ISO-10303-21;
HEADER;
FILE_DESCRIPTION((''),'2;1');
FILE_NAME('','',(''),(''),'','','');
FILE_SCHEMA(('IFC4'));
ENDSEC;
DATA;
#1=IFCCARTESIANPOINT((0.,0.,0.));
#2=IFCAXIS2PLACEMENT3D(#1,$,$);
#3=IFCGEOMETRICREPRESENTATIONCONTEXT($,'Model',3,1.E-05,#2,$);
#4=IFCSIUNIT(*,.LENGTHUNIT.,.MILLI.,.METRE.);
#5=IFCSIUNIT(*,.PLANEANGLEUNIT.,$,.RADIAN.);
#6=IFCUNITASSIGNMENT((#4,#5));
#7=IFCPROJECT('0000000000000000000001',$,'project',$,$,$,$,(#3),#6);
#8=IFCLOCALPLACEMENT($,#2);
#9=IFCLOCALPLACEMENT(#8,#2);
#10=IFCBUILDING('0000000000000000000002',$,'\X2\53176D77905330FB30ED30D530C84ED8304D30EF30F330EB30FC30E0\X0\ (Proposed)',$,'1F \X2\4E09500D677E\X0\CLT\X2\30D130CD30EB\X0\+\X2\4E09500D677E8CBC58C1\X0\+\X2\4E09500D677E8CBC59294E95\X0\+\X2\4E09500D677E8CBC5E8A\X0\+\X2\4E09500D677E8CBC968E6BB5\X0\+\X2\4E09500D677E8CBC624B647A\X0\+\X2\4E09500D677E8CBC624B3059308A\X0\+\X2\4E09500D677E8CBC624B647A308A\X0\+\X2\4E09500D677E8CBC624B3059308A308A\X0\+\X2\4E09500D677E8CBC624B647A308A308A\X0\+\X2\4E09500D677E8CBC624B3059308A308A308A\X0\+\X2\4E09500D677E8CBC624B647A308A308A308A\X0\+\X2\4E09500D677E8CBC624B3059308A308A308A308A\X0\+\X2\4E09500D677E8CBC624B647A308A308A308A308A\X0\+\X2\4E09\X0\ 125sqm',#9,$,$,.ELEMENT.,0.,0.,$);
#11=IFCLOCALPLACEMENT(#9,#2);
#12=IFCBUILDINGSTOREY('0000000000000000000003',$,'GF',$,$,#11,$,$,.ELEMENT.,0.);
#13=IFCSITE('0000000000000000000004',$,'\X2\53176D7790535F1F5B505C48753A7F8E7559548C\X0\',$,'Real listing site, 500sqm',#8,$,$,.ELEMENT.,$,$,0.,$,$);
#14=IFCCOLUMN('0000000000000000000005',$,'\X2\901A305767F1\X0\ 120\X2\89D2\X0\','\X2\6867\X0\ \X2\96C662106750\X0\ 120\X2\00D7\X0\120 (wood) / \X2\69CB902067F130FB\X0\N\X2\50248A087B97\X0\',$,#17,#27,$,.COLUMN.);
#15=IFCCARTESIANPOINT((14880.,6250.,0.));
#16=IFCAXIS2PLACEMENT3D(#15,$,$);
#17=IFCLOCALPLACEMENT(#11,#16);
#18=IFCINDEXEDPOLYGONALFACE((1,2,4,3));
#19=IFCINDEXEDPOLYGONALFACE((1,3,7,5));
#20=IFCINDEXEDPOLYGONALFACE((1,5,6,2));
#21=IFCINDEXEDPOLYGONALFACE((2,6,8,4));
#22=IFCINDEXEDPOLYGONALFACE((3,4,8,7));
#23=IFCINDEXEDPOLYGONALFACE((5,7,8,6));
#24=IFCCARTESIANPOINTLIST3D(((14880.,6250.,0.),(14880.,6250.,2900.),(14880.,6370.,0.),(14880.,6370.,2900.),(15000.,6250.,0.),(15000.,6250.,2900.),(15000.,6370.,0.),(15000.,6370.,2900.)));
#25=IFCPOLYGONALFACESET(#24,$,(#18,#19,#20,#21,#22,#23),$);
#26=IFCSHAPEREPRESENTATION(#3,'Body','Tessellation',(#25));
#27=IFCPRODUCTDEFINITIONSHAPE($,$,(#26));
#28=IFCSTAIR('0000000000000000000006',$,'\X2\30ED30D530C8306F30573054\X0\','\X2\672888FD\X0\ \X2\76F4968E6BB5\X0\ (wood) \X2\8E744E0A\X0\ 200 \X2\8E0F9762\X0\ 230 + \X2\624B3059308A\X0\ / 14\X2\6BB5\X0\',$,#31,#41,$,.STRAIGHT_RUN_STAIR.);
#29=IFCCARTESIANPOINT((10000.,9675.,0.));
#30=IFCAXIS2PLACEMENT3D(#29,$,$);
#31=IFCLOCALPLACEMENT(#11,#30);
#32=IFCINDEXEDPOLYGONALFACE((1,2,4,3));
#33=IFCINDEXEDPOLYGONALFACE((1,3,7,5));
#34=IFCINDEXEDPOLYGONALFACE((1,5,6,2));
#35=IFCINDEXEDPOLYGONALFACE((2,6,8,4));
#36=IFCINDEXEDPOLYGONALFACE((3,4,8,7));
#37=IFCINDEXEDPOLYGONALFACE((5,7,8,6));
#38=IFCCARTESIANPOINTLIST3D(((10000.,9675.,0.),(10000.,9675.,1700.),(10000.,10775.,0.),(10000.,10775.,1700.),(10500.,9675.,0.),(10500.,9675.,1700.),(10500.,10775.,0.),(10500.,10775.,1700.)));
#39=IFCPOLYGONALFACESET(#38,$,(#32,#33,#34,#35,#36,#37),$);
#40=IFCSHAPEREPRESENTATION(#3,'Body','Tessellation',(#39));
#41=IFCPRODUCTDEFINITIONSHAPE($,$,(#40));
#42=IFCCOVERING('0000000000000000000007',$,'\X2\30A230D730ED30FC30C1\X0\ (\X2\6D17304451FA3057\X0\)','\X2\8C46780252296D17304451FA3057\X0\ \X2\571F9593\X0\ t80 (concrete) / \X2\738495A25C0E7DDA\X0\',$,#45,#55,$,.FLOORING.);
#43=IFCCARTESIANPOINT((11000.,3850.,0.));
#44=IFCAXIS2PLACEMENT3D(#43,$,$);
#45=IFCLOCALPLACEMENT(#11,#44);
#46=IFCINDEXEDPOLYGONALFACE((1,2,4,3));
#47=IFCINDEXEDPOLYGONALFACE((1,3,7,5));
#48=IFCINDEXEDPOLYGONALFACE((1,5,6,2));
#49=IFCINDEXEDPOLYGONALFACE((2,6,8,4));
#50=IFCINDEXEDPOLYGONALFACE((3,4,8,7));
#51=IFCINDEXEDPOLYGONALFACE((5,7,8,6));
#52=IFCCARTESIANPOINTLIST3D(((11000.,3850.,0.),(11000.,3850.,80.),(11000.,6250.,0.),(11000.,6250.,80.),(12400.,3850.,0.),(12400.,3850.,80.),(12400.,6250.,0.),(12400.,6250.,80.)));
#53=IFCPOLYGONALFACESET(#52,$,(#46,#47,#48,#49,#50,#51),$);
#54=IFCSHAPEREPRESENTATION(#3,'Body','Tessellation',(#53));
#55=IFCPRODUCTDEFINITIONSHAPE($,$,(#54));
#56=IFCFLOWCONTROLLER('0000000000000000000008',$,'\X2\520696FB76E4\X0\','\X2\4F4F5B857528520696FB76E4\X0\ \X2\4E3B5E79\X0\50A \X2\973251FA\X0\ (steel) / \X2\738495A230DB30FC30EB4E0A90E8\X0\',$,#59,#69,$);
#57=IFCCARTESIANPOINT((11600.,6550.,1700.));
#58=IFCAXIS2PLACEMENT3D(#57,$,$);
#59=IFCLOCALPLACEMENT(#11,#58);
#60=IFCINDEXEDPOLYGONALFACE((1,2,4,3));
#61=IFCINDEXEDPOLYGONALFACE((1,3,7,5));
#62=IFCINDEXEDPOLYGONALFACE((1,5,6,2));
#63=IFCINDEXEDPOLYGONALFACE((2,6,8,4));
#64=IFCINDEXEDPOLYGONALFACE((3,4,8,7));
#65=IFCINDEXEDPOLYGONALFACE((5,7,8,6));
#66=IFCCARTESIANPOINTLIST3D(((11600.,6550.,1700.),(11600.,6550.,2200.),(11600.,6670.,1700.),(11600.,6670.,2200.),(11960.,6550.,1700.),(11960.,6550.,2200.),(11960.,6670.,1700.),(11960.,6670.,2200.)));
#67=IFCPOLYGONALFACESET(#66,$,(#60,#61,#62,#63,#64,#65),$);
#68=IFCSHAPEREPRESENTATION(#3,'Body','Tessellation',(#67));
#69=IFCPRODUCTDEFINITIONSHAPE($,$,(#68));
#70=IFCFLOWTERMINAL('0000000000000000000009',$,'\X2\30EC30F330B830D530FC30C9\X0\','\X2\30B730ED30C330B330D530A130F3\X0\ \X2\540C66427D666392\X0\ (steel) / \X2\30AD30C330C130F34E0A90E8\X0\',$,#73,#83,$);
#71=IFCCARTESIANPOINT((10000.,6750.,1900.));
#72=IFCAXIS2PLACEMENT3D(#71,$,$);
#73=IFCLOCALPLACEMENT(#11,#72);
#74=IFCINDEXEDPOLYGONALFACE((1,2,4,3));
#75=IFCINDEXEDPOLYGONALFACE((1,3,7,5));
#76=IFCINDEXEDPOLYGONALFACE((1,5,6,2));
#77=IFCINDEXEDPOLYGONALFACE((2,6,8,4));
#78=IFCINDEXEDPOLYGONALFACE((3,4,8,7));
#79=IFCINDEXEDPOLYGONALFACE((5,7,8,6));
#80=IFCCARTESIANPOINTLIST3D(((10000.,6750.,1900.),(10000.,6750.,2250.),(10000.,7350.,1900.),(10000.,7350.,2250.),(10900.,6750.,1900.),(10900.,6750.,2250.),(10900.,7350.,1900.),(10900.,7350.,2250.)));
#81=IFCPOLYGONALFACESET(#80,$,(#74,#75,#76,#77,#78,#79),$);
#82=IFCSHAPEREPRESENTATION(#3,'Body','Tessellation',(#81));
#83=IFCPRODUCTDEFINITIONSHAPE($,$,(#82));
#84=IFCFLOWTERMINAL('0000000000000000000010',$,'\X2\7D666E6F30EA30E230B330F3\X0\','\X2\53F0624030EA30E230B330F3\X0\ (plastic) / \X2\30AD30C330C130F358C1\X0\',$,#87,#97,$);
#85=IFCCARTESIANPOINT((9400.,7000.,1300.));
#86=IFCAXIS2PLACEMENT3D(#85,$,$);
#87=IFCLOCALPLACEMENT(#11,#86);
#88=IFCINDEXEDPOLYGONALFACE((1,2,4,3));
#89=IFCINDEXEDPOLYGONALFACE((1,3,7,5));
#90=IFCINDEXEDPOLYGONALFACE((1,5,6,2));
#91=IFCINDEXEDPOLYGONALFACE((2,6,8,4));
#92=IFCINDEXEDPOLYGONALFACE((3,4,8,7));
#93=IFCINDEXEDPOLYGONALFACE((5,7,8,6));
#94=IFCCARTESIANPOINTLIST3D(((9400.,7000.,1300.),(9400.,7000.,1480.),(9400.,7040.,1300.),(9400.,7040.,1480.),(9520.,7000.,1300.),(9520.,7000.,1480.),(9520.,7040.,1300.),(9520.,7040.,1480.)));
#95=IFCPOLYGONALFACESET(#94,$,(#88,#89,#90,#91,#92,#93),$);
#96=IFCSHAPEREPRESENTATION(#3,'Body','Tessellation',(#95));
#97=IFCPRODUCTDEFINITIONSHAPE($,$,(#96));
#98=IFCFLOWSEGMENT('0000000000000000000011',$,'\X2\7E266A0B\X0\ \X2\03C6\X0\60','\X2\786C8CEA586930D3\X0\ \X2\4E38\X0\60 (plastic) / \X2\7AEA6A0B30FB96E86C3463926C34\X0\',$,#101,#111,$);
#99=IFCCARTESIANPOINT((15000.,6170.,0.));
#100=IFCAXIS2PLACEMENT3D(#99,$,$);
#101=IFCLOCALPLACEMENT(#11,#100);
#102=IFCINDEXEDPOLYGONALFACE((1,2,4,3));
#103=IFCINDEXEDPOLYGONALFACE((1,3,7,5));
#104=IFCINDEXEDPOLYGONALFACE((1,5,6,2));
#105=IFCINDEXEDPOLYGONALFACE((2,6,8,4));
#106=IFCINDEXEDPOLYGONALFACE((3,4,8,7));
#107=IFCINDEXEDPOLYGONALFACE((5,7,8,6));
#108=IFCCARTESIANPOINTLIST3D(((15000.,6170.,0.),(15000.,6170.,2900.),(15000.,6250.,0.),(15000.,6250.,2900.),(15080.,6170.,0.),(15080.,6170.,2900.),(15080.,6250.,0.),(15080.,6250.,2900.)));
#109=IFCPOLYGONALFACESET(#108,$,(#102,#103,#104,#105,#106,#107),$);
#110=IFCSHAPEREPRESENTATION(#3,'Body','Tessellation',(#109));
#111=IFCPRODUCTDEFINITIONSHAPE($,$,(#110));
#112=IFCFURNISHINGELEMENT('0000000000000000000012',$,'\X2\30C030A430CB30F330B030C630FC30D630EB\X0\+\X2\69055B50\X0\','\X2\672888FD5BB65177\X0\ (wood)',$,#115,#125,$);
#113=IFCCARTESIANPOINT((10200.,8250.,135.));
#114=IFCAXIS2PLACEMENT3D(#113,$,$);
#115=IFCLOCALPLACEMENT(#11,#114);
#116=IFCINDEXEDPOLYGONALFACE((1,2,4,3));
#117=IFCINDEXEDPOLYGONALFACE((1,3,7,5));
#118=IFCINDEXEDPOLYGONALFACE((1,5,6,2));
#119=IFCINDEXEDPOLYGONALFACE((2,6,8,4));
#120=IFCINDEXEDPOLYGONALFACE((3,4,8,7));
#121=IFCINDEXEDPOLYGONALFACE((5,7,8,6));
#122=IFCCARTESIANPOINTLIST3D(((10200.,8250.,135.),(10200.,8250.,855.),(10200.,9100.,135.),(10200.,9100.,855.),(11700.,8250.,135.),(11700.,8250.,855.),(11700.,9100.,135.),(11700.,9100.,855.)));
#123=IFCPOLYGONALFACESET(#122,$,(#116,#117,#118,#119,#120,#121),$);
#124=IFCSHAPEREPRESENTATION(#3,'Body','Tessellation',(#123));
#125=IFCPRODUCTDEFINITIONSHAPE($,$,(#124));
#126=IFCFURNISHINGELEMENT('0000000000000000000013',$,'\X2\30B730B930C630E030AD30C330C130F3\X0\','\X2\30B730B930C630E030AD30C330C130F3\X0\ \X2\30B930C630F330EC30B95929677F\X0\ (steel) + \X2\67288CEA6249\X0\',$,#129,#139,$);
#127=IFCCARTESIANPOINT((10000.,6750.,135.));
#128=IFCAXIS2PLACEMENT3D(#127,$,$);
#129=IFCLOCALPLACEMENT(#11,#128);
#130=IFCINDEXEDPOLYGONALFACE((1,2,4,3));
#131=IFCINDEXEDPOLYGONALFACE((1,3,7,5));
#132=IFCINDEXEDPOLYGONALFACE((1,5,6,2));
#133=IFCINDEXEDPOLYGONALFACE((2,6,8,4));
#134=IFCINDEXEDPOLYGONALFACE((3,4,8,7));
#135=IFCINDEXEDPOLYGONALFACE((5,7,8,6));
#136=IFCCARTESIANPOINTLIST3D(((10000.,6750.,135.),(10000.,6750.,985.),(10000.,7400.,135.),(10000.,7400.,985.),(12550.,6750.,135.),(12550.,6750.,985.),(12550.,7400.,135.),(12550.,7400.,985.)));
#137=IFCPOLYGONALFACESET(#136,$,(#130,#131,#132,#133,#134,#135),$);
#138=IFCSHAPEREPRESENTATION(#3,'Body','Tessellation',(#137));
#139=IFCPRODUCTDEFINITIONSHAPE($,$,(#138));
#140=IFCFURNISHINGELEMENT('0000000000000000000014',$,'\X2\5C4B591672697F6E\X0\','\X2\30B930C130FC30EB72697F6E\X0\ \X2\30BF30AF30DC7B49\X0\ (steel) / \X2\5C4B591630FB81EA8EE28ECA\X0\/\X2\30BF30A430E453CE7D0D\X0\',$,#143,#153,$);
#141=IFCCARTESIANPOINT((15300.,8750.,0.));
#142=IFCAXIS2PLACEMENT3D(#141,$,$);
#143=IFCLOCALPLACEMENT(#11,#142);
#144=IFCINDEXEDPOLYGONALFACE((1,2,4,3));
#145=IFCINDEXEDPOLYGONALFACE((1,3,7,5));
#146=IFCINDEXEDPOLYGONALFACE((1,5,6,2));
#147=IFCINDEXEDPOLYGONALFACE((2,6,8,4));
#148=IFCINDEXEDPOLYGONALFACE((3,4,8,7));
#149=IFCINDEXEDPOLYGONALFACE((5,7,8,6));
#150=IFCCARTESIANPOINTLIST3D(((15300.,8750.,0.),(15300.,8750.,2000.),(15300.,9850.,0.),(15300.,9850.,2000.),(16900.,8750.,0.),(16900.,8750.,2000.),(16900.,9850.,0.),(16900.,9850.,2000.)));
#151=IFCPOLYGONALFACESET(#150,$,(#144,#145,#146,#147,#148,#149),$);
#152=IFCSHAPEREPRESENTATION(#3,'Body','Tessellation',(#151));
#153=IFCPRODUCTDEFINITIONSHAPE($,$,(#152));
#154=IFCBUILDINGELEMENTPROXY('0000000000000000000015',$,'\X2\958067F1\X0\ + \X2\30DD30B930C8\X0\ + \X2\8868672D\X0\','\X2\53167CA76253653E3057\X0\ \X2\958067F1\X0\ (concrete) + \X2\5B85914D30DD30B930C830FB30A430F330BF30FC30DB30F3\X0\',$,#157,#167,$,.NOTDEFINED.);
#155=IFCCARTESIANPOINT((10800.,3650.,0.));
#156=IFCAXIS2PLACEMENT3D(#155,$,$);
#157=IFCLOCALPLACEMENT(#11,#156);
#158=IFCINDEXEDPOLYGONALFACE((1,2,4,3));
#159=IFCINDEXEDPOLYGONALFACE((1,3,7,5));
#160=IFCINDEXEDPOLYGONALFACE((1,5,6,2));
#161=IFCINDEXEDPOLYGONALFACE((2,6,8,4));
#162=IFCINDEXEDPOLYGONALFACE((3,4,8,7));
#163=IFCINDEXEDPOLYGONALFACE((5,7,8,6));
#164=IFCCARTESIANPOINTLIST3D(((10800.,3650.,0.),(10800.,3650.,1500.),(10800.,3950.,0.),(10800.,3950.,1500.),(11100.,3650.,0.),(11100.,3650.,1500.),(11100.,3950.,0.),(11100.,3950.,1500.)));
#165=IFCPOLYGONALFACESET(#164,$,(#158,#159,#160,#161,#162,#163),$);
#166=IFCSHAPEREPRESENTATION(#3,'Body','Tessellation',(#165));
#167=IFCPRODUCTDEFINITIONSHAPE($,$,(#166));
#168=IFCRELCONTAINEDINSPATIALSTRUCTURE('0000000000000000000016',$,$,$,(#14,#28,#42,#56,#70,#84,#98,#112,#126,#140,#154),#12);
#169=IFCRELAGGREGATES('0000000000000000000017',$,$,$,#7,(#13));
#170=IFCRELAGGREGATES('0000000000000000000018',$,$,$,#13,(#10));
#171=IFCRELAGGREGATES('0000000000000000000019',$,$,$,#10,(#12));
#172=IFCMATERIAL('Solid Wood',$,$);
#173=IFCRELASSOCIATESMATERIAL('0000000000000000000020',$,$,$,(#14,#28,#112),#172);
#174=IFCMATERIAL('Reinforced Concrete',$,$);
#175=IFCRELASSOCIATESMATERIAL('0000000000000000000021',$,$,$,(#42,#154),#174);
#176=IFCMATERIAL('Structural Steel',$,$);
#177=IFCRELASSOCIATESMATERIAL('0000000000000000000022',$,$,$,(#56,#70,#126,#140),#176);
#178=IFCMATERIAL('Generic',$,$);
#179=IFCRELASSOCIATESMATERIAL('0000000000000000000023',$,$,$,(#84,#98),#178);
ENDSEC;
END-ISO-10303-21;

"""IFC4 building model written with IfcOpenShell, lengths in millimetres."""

from ifc_helpers import new_model, si_unit, frame, frame_2d, origin, place, context, project, spatial, rectangle, extrude, material, element, save


model = new_model("IFC4")

# Units and contexts
model_context = context("Model", 3, precision=1e-05, world=origin())
ifc_project = project(units=[si_unit("LENGTHUNIT", "METRE", prefix="MILLI"), si_unit("PLANEANGLEUNIT", "RADIAN")], contexts=[model_context])

# Site, building, storey
site_placement = place(None, origin())
site = spatial("IfcSite", under=ifc_project, at=site_placement, Name="北海道弟子屈町美留和", ObjectType="Real listing site, 500sqm", CompositionType="ELEMENT", RefElevation=0.0)
building_placement = place(site_placement, origin())
building = spatial("IfcBuilding", under=site, at=building_placement, Name="北海道・ロフト付きワンルーム (Proposed)", ObjectType="1F 三倍松CLTパネル+三倍松貼壁+三倍松貼天井+三倍松貼床+三倍松貼階段+三倍松貼手摺+三倍松貼手すり+三倍松貼手摺り+三倍松貼手すりり+三倍松貼手摺りり+三倍松貼手すりりり+三倍松貼手摺りりり+三倍松貼手すりりりり+三倍松貼手摺りりりり+三 125sqm", CompositionType="ELEMENT", ElevationOfRefHeight=0.0, ElevationOfTerrain=0.0)
storey_placement = place(building_placement, origin())
storey = spatial("IfcBuildingStorey", under=building, at=storey_placement, Name="GF", CompositionType="ELEMENT", Elevation=0.0)

# Column
ifc_material_1 = material(Name="Solid Wood")
column_1_placement = place(storey_placement, frame((14880.0, 6250.0, 0.0)))
element("IfcColumn", 1, at=column_1_placement, inside=storey, material=ifc_material_1, Name="通し柱 120角", Description="桧 集成材 120×120 (wood) / 構造柱・N値計算", PredefinedType="COLUMN", context=model_context, shape_type="SweptSolid", body=[
    extrude(rectangle(XDim=120.0, YDim=120.0, at=frame_2d((60.0, 60.0))), frame((14880.0, 6250.0, 0.0)), (0.0, 0.0, 1.0), 2900.0),
])

# Stair
stair_placement = place(storey_placement, frame((10000.0, 9675.0, 0.0)))
element("IfcStair", 2, at=stair_placement, inside=storey, material=ifc_material_1, Name="ロフトはしご", Description="木製 直階段 (wood) 蹴上 200 踏面 230 + 手すり / 14段", PredefinedType="STRAIGHT_RUN_STAIR", context=model_context, shape_type="SweptSolid", body=[
    extrude(rectangle(XDim=500.0, YDim=1100.0, at=frame_2d((250.0, 550.0))), frame((10000.0, 9675.0, 0.0)), (0.0, 0.0, 1.0), 1700.0),
])

# Covering
ifc_material_2 = material(Name="Reinforced Concrete")
covering_placement = place(storey_placement, frame((11000.0, 3850.0, 0.0)))
element("IfcCovering", 3, at=covering_placement, inside=storey, material=ifc_material_2, Name="アプローチ (洗い出し)", Description="豆砂利洗い出し 土間 t80 (concrete) / 玄関導線", PredefinedType="FLOORING", context=model_context, shape_type="SweptSolid", body=[
    extrude(rectangle(XDim=1400.0, YDim=2400.0, at=frame_2d((700.0, 1200.0))), frame((11000.0, 3850.0, 0.0)), (0.0, 0.0, 1.0), 80.0),
])

# Flow controller
ifc_material_3 = material(Name="Structural Steel")
flow_controller_placement = place(storey_placement, frame((11600.0, 6550.0, 1700.0)))
element("IfcFlowController", 4, at=flow_controller_placement, inside=storey, material=ifc_material_3, Name="分電盤", Description="住宅用分電盤 主幹50A 露出 (steel) / 玄関ホール上部", context=model_context, shape_type="SweptSolid", body=[
    extrude(rectangle(XDim=360.0, YDim=120.0, at=frame_2d((180.0, 60.0))), frame((11600.0, 6550.0, 1700.0)), (0.0, 0.0, 1.0), 500.0),
])

# Flow terminals
flow_terminal_1_placement = place(storey_placement, frame((10000.0, 6750.0, 1900.0)))
element("IfcFlowTerminal", 5, at=flow_terminal_1_placement, inside=storey, material=ifc_material_3, Name="レンジフード", Description="シロッコファン 同時給排 (steel) / キッチン上部", context=model_context, shape_type="SweptSolid", body=[
    extrude(rectangle(XDim=900.0, YDim=600.0, at=frame_2d((450.0, 300.0))), frame((10000.0, 6750.0, 1900.0)), (0.0, 0.0, 1.0), 350.0),
])
ifc_material_4 = material(Name="Generic")
flow_terminal_2_placement = place(storey_placement, frame((9400.0, 7000.0, 1300.0)))
element("IfcFlowTerminal", 6, at=flow_terminal_2_placement, inside=storey, material=ifc_material_4, Name="給湯リモコン", Description="台所リモコン (plastic) / キッチン壁", context=model_context, shape_type="SweptSolid", body=[
    extrude(rectangle(XDim=120.0, YDim=40.0, at=frame_2d((60.0, 20.0))), frame((9400.0, 7000.0, 1300.0)), (0.0, 0.0, 1.0), 180.0),
])

# Flow segment
flow_segment_placement = place(storey_placement, frame((15000.0, 6170.0, 0.0)))
element("IfcFlowSegment", 7, at=flow_segment_placement, inside=storey, material=ifc_material_4, Name="縦樋 φ60", Description="硬質塩ビ 丸60 (plastic) / 竪樋・雨水排水", context=model_context, shape_type="SweptSolid", body=[
    extrude(rectangle(XDim=80.0, YDim=80.0, at=frame_2d((40.0, 40.0))), frame((15000.0, 6170.0, 0.0)), (0.0, 0.0, 1.0), 2900.0),
])

# Furnishing elements
furnishing_1_placement = place(storey_placement, frame((10200.0, 8250.0, 135.0)))
element("IfcFurnishingElement", 8, at=furnishing_1_placement, inside=storey, material=ifc_material_1, Name="ダイニングテーブル+椅子", Description="木製家具 (wood)", context=model_context, shape_type="SweptSolid", body=[
    extrude(rectangle(XDim=1500.0, YDim=850.0, at=frame_2d((750.0, 425.0))), frame((10200.0, 8250.0, 135.0)), (0.0, 0.0, 1.0), 720.0),
])
furnishing_2_placement = place(storey_placement, frame((10000.0, 6750.0, 135.0)))
element("IfcFurnishingElement", 9, at=furnishing_2_placement, inside=storey, material=ifc_material_3, Name="システムキッチン", Description="システムキッチン ステンレス天板 (steel) + 木質扉", context=model_context, shape_type="SweptSolid", body=[
    extrude(rectangle(XDim=2550.0, YDim=650.0, at=frame_2d((1275.0, 325.0))), frame((10000.0, 6750.0, 135.0)), (0.0, 0.0, 1.0), 850.0),
])
furnishing_3_placement = place(storey_placement, frame((15300.0, 8750.0, 0.0)))
element("IfcFurnishingElement", 10, at=furnishing_3_placement, inside=storey, material=ifc_material_3, Name="屋外物置", Description="スチール物置 タクボ等 (steel) / 屋外・自転車/タイヤ収納", context=model_context, shape_type="SweptSolid", body=[
    extrude(rectangle(XDim=1600.0, YDim=1100.0, at=frame_2d((800.0, 550.0))), frame((15300.0, 8750.0, 0.0)), (0.0, 0.0, 1.0), 2000.0),
])

# Building element proxy
proxy_placement = place(storey_placement, frame((10800.0, 3650.0, 0.0)))
element("IfcBuildingElementProxy", 11, at=proxy_placement, inside=storey, material=ifc_material_2, Name="門柱 + ポスト + 表札", Description="化粧打放し 門柱 (concrete) + 宅配ポスト・インターホン", PredefinedType="NOTDEFINED", context=model_context, shape_type="SweptSolid", body=[
    extrude(rectangle(XDim=300.0, YDim=300.0, at=frame_2d((150.0, 150.0))), frame((10800.0, 3650.0, 0.0)), (0.0, 0.0, 1.0), 1500.0),
])

save(model, "model.ifc")
